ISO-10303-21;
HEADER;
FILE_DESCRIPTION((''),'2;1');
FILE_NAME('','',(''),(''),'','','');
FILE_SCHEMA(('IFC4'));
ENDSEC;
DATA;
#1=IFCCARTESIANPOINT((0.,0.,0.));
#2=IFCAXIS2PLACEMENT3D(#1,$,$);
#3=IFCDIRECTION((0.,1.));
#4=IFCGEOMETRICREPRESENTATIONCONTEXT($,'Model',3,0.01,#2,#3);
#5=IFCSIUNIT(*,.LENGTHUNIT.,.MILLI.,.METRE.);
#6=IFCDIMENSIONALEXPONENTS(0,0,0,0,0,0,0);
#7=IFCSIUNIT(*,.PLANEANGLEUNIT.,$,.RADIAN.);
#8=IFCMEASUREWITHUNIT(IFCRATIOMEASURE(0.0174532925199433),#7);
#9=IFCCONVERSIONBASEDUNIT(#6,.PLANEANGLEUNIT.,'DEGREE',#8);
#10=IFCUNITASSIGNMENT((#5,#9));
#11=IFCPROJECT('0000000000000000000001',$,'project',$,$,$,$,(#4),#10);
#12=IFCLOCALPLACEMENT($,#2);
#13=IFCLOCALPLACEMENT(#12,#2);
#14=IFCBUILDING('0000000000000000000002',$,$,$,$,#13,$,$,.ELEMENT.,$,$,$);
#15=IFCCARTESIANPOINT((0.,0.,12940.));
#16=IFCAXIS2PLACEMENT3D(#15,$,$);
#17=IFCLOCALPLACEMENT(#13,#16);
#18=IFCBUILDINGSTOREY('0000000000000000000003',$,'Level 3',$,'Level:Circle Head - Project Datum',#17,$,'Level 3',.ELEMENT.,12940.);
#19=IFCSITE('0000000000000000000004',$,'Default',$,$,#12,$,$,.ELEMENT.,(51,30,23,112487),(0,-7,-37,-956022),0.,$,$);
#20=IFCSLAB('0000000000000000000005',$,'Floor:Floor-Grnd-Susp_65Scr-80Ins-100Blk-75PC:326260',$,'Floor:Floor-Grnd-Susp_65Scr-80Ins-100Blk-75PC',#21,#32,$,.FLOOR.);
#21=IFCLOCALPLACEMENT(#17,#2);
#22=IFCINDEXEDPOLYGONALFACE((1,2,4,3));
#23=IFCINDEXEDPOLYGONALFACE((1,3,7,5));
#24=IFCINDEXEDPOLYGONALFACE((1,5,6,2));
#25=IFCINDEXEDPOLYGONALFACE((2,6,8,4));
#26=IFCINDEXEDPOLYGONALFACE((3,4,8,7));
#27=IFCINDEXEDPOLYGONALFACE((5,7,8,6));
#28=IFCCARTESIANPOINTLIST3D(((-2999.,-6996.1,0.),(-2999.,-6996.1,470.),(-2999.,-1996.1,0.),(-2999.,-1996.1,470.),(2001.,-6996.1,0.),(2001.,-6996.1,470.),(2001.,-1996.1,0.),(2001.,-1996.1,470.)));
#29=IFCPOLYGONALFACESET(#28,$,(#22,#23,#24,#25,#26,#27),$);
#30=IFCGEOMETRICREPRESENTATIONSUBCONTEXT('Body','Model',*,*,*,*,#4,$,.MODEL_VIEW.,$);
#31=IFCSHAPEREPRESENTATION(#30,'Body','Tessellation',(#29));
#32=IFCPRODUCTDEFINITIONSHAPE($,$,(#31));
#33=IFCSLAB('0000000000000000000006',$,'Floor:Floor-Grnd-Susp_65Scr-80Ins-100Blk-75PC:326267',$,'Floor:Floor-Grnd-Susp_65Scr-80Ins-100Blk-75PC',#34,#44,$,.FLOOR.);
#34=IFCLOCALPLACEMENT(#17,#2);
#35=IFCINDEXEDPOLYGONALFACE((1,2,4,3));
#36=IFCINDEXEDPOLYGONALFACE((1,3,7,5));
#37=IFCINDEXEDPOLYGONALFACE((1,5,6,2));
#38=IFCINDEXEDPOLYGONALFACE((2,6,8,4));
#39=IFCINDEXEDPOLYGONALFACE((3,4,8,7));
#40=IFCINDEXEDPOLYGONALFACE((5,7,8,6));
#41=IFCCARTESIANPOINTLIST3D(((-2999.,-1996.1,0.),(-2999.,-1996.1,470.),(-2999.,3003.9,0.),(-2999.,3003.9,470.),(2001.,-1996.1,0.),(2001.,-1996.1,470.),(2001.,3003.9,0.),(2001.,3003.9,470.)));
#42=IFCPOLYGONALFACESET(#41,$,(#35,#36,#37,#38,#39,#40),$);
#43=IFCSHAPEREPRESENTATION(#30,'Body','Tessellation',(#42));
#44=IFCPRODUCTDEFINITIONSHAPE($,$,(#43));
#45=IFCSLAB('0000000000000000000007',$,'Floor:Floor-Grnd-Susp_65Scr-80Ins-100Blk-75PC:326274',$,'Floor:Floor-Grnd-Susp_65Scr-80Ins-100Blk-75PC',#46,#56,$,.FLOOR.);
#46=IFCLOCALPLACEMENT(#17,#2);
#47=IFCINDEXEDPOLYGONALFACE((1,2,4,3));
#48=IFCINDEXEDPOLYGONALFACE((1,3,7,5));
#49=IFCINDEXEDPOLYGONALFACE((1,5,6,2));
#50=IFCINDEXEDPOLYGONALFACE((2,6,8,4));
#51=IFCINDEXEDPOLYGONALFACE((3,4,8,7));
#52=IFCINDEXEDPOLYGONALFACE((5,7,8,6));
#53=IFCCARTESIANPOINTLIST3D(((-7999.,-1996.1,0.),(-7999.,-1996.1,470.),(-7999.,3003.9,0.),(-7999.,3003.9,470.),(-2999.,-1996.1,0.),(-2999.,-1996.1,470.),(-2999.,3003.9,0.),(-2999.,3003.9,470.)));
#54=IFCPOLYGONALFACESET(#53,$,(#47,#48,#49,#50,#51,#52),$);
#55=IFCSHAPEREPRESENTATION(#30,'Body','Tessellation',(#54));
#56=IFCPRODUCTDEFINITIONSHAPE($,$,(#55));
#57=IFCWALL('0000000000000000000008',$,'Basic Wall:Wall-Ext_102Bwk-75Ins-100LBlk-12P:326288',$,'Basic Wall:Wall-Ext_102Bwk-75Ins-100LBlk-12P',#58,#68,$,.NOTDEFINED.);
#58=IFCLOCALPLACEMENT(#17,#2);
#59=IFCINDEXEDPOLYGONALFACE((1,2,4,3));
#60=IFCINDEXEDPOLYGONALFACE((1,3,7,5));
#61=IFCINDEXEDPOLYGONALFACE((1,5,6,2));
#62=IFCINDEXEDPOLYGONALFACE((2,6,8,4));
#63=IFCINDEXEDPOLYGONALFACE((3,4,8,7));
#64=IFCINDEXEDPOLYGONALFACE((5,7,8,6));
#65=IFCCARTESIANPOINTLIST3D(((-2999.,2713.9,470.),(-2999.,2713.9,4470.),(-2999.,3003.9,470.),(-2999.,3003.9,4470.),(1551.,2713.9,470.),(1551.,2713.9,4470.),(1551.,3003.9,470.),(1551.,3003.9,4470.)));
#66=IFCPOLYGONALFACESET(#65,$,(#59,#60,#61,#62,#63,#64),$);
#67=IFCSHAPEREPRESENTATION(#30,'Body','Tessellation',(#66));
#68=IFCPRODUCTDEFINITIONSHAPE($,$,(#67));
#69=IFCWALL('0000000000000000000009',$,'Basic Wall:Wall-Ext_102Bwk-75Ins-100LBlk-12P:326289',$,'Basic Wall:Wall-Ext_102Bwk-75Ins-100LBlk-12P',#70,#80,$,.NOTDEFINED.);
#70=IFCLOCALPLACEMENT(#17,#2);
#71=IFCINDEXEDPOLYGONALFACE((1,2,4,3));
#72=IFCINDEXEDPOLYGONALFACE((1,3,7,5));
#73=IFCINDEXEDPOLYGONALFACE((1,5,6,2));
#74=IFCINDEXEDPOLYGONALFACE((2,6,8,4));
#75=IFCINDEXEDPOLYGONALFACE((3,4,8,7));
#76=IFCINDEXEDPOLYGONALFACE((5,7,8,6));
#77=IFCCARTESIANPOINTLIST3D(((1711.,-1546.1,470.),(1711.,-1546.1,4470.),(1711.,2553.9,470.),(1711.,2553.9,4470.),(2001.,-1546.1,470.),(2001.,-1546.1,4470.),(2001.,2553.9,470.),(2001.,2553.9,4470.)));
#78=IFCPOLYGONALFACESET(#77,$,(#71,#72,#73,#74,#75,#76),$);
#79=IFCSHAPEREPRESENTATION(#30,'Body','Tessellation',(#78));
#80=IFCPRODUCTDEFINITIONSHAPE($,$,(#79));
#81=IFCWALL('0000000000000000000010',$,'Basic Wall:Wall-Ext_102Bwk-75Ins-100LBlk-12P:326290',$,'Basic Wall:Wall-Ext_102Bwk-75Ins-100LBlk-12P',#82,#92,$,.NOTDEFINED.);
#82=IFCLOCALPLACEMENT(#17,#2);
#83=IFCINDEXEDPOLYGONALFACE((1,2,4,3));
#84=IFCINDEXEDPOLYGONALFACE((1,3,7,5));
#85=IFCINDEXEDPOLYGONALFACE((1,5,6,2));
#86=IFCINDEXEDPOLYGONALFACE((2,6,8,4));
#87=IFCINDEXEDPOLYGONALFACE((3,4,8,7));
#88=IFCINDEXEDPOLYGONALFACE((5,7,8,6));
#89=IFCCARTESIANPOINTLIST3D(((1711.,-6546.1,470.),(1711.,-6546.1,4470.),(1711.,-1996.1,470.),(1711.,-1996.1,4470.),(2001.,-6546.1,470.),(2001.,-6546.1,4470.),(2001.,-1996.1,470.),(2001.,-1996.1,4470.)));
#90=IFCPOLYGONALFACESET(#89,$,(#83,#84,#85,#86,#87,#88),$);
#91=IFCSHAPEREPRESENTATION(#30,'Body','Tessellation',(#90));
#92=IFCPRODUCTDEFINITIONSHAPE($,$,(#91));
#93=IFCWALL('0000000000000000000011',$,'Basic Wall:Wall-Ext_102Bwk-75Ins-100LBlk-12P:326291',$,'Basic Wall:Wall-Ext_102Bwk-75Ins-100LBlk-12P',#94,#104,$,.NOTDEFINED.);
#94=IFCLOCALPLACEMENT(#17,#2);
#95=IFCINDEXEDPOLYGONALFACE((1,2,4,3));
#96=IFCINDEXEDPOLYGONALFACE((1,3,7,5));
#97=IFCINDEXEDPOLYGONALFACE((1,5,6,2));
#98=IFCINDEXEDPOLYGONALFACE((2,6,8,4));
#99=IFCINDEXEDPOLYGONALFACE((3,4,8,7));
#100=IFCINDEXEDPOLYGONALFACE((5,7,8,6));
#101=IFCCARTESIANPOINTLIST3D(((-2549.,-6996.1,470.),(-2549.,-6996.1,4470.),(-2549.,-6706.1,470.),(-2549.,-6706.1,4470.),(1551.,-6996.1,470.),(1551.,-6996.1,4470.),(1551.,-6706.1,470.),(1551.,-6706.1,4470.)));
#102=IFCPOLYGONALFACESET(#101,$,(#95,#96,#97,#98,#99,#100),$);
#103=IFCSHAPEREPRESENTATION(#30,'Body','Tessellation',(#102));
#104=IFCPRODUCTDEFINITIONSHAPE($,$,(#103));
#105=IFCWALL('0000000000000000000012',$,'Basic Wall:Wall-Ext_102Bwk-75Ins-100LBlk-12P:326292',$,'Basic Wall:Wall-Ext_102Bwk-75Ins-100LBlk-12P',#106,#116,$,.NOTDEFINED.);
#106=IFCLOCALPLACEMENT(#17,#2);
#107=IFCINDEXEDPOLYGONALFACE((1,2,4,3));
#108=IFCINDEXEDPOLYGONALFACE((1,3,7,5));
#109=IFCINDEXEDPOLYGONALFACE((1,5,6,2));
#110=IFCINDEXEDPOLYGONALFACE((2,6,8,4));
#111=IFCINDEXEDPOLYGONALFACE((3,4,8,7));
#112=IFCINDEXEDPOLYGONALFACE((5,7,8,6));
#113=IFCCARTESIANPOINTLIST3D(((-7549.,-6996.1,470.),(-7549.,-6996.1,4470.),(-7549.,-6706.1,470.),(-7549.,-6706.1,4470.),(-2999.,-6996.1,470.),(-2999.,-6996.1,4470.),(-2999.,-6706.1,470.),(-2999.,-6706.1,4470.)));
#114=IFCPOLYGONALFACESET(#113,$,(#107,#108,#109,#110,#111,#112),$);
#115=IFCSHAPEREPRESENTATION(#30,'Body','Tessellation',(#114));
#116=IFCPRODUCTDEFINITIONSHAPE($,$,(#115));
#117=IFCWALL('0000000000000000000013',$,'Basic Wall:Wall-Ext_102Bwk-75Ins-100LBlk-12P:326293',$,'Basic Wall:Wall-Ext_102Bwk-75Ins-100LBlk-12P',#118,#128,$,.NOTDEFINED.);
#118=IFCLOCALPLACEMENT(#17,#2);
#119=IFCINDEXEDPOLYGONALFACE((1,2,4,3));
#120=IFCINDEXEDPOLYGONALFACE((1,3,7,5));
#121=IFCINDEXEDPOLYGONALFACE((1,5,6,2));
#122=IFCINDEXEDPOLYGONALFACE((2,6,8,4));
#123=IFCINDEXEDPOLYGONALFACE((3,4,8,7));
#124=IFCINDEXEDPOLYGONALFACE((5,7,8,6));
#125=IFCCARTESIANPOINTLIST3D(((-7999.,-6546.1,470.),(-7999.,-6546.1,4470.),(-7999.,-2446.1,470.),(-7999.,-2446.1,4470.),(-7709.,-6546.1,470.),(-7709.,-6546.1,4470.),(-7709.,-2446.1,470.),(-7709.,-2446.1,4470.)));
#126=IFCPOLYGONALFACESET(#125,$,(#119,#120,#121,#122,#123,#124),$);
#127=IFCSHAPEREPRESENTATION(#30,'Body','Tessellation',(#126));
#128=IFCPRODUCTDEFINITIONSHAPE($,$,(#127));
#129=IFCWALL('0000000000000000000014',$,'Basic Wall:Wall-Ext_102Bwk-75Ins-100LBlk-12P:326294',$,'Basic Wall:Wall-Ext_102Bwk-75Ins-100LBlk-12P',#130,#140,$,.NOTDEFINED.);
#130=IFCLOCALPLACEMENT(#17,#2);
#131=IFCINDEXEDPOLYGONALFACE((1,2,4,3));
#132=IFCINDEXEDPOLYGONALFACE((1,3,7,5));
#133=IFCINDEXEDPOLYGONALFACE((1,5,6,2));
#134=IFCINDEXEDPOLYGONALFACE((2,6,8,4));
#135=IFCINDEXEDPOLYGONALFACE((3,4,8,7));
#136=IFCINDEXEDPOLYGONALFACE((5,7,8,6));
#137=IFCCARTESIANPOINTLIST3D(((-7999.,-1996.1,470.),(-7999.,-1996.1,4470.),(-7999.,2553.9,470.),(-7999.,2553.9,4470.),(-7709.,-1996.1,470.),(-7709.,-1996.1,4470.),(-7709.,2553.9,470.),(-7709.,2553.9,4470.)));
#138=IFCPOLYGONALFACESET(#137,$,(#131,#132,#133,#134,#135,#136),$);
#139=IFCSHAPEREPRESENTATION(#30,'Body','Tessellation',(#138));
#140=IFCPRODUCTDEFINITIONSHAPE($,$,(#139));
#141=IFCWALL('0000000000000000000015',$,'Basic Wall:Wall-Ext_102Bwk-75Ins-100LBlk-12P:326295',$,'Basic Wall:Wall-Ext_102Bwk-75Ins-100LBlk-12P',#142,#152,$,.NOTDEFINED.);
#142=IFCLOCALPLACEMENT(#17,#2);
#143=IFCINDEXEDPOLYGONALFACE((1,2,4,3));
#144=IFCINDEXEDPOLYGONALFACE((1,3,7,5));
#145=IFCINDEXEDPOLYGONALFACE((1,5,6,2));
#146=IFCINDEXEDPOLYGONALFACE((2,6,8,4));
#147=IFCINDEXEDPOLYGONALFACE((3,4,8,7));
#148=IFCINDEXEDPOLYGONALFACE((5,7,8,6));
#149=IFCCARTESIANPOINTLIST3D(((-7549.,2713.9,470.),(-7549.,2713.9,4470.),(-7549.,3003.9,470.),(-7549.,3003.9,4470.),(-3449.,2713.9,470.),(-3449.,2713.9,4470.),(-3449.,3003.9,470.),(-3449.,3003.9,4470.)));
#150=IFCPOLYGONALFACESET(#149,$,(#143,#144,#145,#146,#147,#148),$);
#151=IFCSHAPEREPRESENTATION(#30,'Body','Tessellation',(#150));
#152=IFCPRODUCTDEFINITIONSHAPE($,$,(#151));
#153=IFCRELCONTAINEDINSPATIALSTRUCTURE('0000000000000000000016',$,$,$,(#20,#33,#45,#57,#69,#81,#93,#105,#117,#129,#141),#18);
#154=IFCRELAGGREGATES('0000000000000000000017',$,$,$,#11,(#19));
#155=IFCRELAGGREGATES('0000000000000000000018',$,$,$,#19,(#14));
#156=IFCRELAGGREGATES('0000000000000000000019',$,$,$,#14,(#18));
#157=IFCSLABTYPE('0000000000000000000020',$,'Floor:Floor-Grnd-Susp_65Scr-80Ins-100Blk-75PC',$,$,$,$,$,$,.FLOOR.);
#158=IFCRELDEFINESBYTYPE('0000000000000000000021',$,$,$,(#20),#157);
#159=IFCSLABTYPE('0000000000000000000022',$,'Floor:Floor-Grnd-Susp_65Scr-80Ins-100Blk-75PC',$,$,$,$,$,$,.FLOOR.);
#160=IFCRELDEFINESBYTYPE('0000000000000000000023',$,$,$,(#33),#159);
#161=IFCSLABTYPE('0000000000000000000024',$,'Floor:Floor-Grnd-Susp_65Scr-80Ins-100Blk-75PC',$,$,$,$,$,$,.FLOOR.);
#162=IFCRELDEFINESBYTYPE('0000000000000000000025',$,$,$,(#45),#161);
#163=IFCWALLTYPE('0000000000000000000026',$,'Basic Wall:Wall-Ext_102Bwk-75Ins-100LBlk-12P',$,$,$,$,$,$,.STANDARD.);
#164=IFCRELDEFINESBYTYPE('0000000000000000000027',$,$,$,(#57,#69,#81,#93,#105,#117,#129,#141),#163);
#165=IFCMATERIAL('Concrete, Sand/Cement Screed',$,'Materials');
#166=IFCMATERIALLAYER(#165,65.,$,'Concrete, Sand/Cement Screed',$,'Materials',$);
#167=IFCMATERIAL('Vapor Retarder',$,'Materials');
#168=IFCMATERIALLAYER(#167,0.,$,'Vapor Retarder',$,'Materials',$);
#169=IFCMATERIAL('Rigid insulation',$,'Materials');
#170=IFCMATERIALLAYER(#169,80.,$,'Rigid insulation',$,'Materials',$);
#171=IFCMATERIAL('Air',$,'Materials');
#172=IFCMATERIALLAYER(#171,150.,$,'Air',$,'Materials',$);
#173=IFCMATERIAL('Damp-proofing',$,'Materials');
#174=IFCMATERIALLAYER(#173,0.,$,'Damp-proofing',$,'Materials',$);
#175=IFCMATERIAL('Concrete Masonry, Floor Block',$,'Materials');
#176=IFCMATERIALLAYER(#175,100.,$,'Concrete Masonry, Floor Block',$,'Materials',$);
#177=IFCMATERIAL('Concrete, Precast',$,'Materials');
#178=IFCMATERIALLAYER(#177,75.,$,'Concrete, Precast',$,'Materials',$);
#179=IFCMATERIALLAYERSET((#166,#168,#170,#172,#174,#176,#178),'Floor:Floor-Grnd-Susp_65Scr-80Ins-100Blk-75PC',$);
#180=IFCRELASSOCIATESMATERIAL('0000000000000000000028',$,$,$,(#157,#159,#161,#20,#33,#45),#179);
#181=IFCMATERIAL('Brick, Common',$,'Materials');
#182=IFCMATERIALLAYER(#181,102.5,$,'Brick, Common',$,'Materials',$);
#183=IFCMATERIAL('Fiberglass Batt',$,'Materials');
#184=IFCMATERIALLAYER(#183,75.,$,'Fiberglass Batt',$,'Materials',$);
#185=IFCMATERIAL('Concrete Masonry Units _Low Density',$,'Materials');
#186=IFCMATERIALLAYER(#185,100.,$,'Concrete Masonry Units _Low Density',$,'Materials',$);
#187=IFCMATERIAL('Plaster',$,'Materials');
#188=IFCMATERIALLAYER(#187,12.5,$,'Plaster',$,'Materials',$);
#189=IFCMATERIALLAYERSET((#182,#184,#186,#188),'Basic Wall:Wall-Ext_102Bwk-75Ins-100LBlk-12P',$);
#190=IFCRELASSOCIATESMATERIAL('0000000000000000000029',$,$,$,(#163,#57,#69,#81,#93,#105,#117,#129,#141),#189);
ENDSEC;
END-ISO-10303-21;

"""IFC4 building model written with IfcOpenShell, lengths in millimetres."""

from ifc_helpers import new_model, entity, si_unit, converted_unit, direction, frame, frame_2d, origin, origin_2d_with_axis, place, context, subcontext, project, spatial, rectangle, extrude, material, layer, layer_set, layer_usage, type_object, element, save


model = new_model("IFC4")

# Units and contexts
model_context = context("Model", 3, precision=0.01, world=origin(), true_north=direction((0.0, 1.0)))
body_context = subcontext(model_context, "Body", "Model", "MODEL_VIEW")
ifc_project = project(units=[si_unit("LENGTHUNIT", "METRE", prefix="MILLI"), converted_unit("PLANEANGLEUNIT", "DEGREE", entity("IfcRatioMeasure", 0.0174532925199433), si_unit("PLANEANGLEUNIT", "RADIAN"), dimensions=[0, 0, 0, 0, 0, 0, 0])], contexts=[model_context])

# Site, building, storey
site_placement = place(None, origin())
site = spatial("IfcSite", under=ifc_project, at=site_placement, Name="Default", CompositionType="ELEMENT", RefLatitude=(51, 30, 23, 112487), RefLongitude=(0, -7, -37, -956022), RefElevation=0.0)
building_placement = place(site_placement, origin())
building = spatial("IfcBuilding", under=site, at=building_placement, CompositionType="ELEMENT")
storey_placement = place(building_placement, frame((0.0, 0.0, 12940.0)))
storey = spatial("IfcBuildingStorey", under=building, at=storey_placement, Name="Level 3", ObjectType="Level:Circle Head - Project Datum", LongName="Level 3", CompositionType="ELEMENT", Elevation=12940.0)

# Slabs
ifc_material_1 = material(Name="Concrete, Sand/Cement Screed", Category="Materials")
ifc_layer_1 = layer(ifc_material_1, 65.0, Name="Concrete, Sand/Cement Screed", Category="Materials")
ifc_material_2 = material(Name="Vapor Retarder", Category="Materials")
ifc_layer_2 = layer(ifc_material_2, 0.0, Name="Vapor Retarder", Category="Materials")
ifc_material_3 = material(Name="Rigid insulation", Category="Materials")
ifc_layer_3 = layer(ifc_material_3, 80.0, Name="Rigid insulation", Category="Materials")
ifc_material_4 = material(Name="Air", Category="Materials")
ifc_layer_4 = layer(ifc_material_4, 150.0, Name="Air", Category="Materials")
ifc_material_5 = material(Name="Damp-proofing", Category="Materials")
ifc_layer_5 = layer(ifc_material_5, 0.0, Name="Damp-proofing", Category="Materials")
ifc_material_6 = material(Name="Concrete Masonry, Floor Block", Category="Materials")
ifc_layer_6 = layer(ifc_material_6, 100.0, Name="Concrete Masonry, Floor Block", Category="Materials")
ifc_material_7 = material(Name="Concrete, Precast", Category="Materials")
ifc_layer_7 = layer(ifc_material_7, 75.0, Name="Concrete, Precast", Category="Materials")
ifc_layer_set_1 = layer_set([ifc_layer_1, ifc_layer_2, ifc_layer_3, ifc_layer_4, ifc_layer_5, ifc_layer_6, ifc_layer_7], Name="Floor:Floor-Grnd-Susp_65Scr-80Ins-100Blk-75PC")
ifc_layer_usage_1 = layer_usage(ifc_layer_set_1, "AXIS3", "POSITIVE", 0.0)
slab_type_1 = type_object("IfcSlabType", Name="Floor:Floor-Grnd-Susp_65Scr-80Ins-100Blk-75PC", PredefinedType="FLOOR", material=ifc_layer_set_1)
slab_1_placement = place(storey_placement, origin())
element("IfcSlab", 1, at=slab_1_placement, inside=storey, type_object=slab_type_1, material=ifc_layer_usage_1, Name="Floor:Floor-Grnd-Susp_65Scr-80Ins-100Blk-75PC:326260", ObjectType="Floor:Floor-Grnd-Susp_65Scr-80Ins-100Blk-75PC", PredefinedType="FLOOR", context=body_context, shape_type="SweptSolid", body=[
    extrude(rectangle(XDim=5000.0, YDim=5000.0, at=frame_2d((0.0, 0.0), x_axis=(1.0, 0.0))), frame((-499.0, -4496.1, 470.0), z_axis=(0.0, 0.0, -1.0), x_axis=(0.0, 1.0, 0.0)), (0.0, 0.0, 1.0), 470.0),
])
ifc_layer_usage_2 = layer_usage(ifc_layer_set_1, "AXIS3", "POSITIVE", 0.0)
slab_type_2 = type_object("IfcSlabType", Name="Floor:Floor-Grnd-Susp_65Scr-80Ins-100Blk-75PC", PredefinedType="FLOOR", material=ifc_layer_set_1)
slab_2_placement = place(storey_placement, origin())
element("IfcSlab", 2, at=slab_2_placement, inside=storey, type_object=slab_type_2, material=ifc_layer_usage_2, Name="Floor:Floor-Grnd-Susp_65Scr-80Ins-100Blk-75PC:326267", ObjectType="Floor:Floor-Grnd-Susp_65Scr-80Ins-100Blk-75PC", PredefinedType="FLOOR", context=body_context, shape_type="SweptSolid", body=[
    extrude(rectangle(XDim=5000.0, YDim=5000.0, at=origin_2d_with_axis()), frame((-499.0, 503.9, 470.0), z_axis=(0.0, 0.0, -1.0), x_axis=(0.0, 1.0, 0.0)), (0.0, 0.0, 1.0), 470.0),
])
ifc_layer_usage_3 = layer_usage(ifc_layer_set_1, "AXIS3", "POSITIVE", 0.0)
slab_type_3 = type_object("IfcSlabType", Name="Floor:Floor-Grnd-Susp_65Scr-80Ins-100Blk-75PC", PredefinedType="FLOOR", material=ifc_layer_set_1)
slab_3_placement = place(storey_placement, origin())
element("IfcSlab", 3, at=slab_3_placement, inside=storey, type_object=slab_type_3, material=ifc_layer_usage_3, Name="Floor:Floor-Grnd-Susp_65Scr-80Ins-100Blk-75PC:326274", ObjectType="Floor:Floor-Grnd-Susp_65Scr-80Ins-100Blk-75PC", PredefinedType="FLOOR", context=body_context, shape_type="SweptSolid", body=[
    extrude(rectangle(XDim=5000.0, YDim=5000.0, at=origin_2d_with_axis()), frame((-5499.0, 503.9, 470.0), z_axis=(0.0, 0.0, -1.0), x_axis=(0.0, 1.0, 0.0)), (0.0, 0.0, 1.0), 470.0),
])

# Walls
ifc_material_8 = material(Name="Brick, Common", Category="Materials")
ifc_layer_8 = layer(ifc_material_8, 102.5, Name="Brick, Common", Category="Materials")
ifc_material_9 = material(Name="Fiberglass Batt", Category="Materials")
ifc_layer_9 = layer(ifc_material_9, 75.0, Name="Fiberglass Batt", Category="Materials")
ifc_material_10 = material(Name="Concrete Masonry Units _Low Density", Category="Materials")
ifc_layer_10 = layer(ifc_material_10, 100.0, Name="Concrete Masonry Units _Low Density", Category="Materials")
ifc_material_11 = material(Name="Plaster", Category="Materials")
ifc_layer_11 = layer(ifc_material_11, 12.5, Name="Plaster", Category="Materials")
ifc_layer_set_2 = layer_set([ifc_layer_8, ifc_layer_9, ifc_layer_10, ifc_layer_11], Name="Basic Wall:Wall-Ext_102Bwk-75Ins-100LBlk-12P")
ifc_layer_usage_4 = layer_usage(ifc_layer_set_2, "AXIS2", "NEGATIVE", 145.0)
wall_type = type_object("IfcWallType", Name="Basic Wall:Wall-Ext_102Bwk-75Ins-100LBlk-12P", PredefinedType="STANDARD", material=ifc_layer_set_2)
wall_1_placement = place(storey_placement, frame((-2999.0, 2858.9, 470.0)))
element("IfcWall", 4, at=wall_1_placement, inside=storey, type_object=wall_type, material=ifc_layer_usage_4, Name="Basic Wall:Wall-Ext_102Bwk-75Ins-100LBlk-12P:326288", ObjectType="Basic Wall:Wall-Ext_102Bwk-75Ins-100LBlk-12P", PredefinedType="NOTDEFINED", context=body_context, shape_type="SweptSolid", body=[
    extrude(rectangle(XDim=4550.0, YDim=290.0, at=frame_2d((2275.0, 0.0), x_axis=(-1.0, 0.0))), origin(), (0.0, 0.0, 1.0), 4000.0),
])
ifc_layer_usage_5 = layer_usage(ifc_layer_set_2, "AXIS2", "NEGATIVE", 145.0)
wall_2_placement = place(storey_placement, frame((1856.0, 2553.9, 470.0), z_axis=(0.0, 0.0, 1.0), x_axis=(0.0, -1.0, 0.0)))
element("IfcWall", 5, at=wall_2_placement, inside=storey, type_object=wall_type, material=ifc_layer_usage_5, Name="Basic Wall:Wall-Ext_102Bwk-75Ins-100LBlk-12P:326289", ObjectType="Basic Wall:Wall-Ext_102Bwk-75Ins-100LBlk-12P", PredefinedType="NOTDEFINED", context=body_context, shape_type="SweptSolid", body=[
    extrude(rectangle(XDim=4100.0, YDim=290.0, at=frame_2d((2050.0, 0.0), x_axis=(-1.0, 0.0))), origin(), (0.0, 0.0, 1.0), 4000.0),
])
ifc_layer_usage_6 = layer_usage(ifc_layer_set_2, "AXIS2", "NEGATIVE", 145.0)
wall_3_placement = place(storey_placement, frame((1856.0, -1996.1, 470.0), z_axis=(0.0, 0.0, 1.0), x_axis=(0.0, -1.0, 0.0)))
element("IfcWall", 6, at=wall_3_placement, inside=storey, type_object=wall_type, material=ifc_layer_usage_6, Name="Basic Wall:Wall-Ext_102Bwk-75Ins-100LBlk-12P:326290", ObjectType="Basic Wall:Wall-Ext_102Bwk-75Ins-100LBlk-12P", PredefinedType="NOTDEFINED", context=body_context, shape_type="SweptSolid", body=[
    extrude(rectangle(XDim=4550.0, YDim=290.0, at=frame_2d((2275.0, 0.0), x_axis=(-1.0, 0.0))), origin(), (0.0, 0.0, 1.0), 4000.0),
])
ifc_layer_usage_7 = layer_usage(ifc_layer_set_2, "AXIS2", "NEGATIVE", 145.0)
wall_4_placement = place(storey_placement, frame((1551.0, -6851.1, 470.0), z_axis=(0.0, 0.0, 1.0), x_axis=(-1.0, 0.0, 0.0)))
element("IfcWall", 7, at=wall_4_placement, inside=storey, type_object=wall_type, material=ifc_layer_usage_7, Name="Basic Wall:Wall-Ext_102Bwk-75Ins-100LBlk-12P:326291", ObjectType="Basic Wall:Wall-Ext_102Bwk-75Ins-100LBlk-12P", PredefinedType="NOTDEFINED", context=body_context, shape_type="SweptSolid", body=[
    extrude(rectangle(XDim=4100.0, YDim=290.0, at=frame_2d((2050.0, 0.0), x_axis=(-1.0, 0.0))), origin(), (0.0, 0.0, 1.0), 4000.0),
])
ifc_layer_usage_8 = layer_usage(ifc_layer_set_2, "AXIS2", "NEGATIVE", 145.0)
wall_5_placement = place(storey_placement, frame((-2999.0, -6851.1, 470.0), z_axis=(0.0, 0.0, 1.0), x_axis=(-1.0, 0.0, 0.0)))
element("IfcWall", 8, at=wall_5_placement, inside=storey, type_object=wall_type, material=ifc_layer_usage_8, Name="Basic Wall:Wall-Ext_102Bwk-75Ins-100LBlk-12P:326292", ObjectType="Basic Wall:Wall-Ext_102Bwk-75Ins-100LBlk-12P", PredefinedType="NOTDEFINED", context=body_context, shape_type="SweptSolid", body=[
    extrude(rectangle(XDim=4550.0, YDim=290.0, at=frame_2d((2275.0, 0.0), x_axis=(-1.0, 0.0))), origin(), (0.0, 0.0, 1.0), 4000.0),
])
ifc_layer_usage_9 = layer_usage(ifc_layer_set_2, "AXIS2", "NEGATIVE", 145.0)
wall_6_placement = place(storey_placement, frame((-7854.0, -6546.1, 470.0), z_axis=(0.0, 0.0, 1.0), x_axis=(0.0, 1.0, 0.0)))
element("IfcWall", 9, at=wall_6_placement, inside=storey, type_object=wall_type, material=ifc_layer_usage_9, Name="Basic Wall:Wall-Ext_102Bwk-75Ins-100LBlk-12P:326293", ObjectType="Basic Wall:Wall-Ext_102Bwk-75Ins-100LBlk-12P", PredefinedType="NOTDEFINED", context=body_context, shape_type="SweptSolid", body=[
    extrude(rectangle(XDim=4100.0, YDim=290.0, at=frame_2d((2050.0, 0.0), x_axis=(-1.0, 0.0))), origin(), (0.0, 0.0, 1.0), 4000.0),
])
ifc_layer_usage_10 = layer_usage(ifc_layer_set_2, "AXIS2", "NEGATIVE", 145.0)
wall_7_placement = place(storey_placement, frame((-7854.0, -1996.1, 470.0), z_axis=(0.0, 0.0, 1.0), x_axis=(0.0, 1.0, 0.0)))
element("IfcWall", 10, at=wall_7_placement, inside=storey, type_object=wall_type, material=ifc_layer_usage_10, Name="Basic Wall:Wall-Ext_102Bwk-75Ins-100LBlk-12P:326294", ObjectType="Basic Wall:Wall-Ext_102Bwk-75Ins-100LBlk-12P", PredefinedType="NOTDEFINED", context=body_context, shape_type="SweptSolid", body=[
    extrude(rectangle(XDim=4550.0, YDim=290.0, at=frame_2d((2275.0, 0.0), x_axis=(-1.0, 0.0))), origin(), (0.0, 0.0, 1.0), 4000.0),
])
ifc_layer_usage_11 = layer_usage(ifc_layer_set_2, "AXIS2", "NEGATIVE", 145.0)
wall_8_placement = place(storey_placement, frame((-7549.0, 2858.9, 470.0)))
element("IfcWall", 11, at=wall_8_placement, inside=storey, type_object=wall_type, material=ifc_layer_usage_11, Name="Basic Wall:Wall-Ext_102Bwk-75Ins-100LBlk-12P:326295", ObjectType="Basic Wall:Wall-Ext_102Bwk-75Ins-100LBlk-12P", PredefinedType="NOTDEFINED", context=body_context, shape_type="SweptSolid", body=[
    extrude(rectangle(XDim=4100.0, YDim=290.0, at=frame_2d((2050.0, 0.0), x_axis=(-1.0, 0.0))), origin(), (0.0, 0.0, 1.0), 4000.0),
])

save(model, "model.ifc")
